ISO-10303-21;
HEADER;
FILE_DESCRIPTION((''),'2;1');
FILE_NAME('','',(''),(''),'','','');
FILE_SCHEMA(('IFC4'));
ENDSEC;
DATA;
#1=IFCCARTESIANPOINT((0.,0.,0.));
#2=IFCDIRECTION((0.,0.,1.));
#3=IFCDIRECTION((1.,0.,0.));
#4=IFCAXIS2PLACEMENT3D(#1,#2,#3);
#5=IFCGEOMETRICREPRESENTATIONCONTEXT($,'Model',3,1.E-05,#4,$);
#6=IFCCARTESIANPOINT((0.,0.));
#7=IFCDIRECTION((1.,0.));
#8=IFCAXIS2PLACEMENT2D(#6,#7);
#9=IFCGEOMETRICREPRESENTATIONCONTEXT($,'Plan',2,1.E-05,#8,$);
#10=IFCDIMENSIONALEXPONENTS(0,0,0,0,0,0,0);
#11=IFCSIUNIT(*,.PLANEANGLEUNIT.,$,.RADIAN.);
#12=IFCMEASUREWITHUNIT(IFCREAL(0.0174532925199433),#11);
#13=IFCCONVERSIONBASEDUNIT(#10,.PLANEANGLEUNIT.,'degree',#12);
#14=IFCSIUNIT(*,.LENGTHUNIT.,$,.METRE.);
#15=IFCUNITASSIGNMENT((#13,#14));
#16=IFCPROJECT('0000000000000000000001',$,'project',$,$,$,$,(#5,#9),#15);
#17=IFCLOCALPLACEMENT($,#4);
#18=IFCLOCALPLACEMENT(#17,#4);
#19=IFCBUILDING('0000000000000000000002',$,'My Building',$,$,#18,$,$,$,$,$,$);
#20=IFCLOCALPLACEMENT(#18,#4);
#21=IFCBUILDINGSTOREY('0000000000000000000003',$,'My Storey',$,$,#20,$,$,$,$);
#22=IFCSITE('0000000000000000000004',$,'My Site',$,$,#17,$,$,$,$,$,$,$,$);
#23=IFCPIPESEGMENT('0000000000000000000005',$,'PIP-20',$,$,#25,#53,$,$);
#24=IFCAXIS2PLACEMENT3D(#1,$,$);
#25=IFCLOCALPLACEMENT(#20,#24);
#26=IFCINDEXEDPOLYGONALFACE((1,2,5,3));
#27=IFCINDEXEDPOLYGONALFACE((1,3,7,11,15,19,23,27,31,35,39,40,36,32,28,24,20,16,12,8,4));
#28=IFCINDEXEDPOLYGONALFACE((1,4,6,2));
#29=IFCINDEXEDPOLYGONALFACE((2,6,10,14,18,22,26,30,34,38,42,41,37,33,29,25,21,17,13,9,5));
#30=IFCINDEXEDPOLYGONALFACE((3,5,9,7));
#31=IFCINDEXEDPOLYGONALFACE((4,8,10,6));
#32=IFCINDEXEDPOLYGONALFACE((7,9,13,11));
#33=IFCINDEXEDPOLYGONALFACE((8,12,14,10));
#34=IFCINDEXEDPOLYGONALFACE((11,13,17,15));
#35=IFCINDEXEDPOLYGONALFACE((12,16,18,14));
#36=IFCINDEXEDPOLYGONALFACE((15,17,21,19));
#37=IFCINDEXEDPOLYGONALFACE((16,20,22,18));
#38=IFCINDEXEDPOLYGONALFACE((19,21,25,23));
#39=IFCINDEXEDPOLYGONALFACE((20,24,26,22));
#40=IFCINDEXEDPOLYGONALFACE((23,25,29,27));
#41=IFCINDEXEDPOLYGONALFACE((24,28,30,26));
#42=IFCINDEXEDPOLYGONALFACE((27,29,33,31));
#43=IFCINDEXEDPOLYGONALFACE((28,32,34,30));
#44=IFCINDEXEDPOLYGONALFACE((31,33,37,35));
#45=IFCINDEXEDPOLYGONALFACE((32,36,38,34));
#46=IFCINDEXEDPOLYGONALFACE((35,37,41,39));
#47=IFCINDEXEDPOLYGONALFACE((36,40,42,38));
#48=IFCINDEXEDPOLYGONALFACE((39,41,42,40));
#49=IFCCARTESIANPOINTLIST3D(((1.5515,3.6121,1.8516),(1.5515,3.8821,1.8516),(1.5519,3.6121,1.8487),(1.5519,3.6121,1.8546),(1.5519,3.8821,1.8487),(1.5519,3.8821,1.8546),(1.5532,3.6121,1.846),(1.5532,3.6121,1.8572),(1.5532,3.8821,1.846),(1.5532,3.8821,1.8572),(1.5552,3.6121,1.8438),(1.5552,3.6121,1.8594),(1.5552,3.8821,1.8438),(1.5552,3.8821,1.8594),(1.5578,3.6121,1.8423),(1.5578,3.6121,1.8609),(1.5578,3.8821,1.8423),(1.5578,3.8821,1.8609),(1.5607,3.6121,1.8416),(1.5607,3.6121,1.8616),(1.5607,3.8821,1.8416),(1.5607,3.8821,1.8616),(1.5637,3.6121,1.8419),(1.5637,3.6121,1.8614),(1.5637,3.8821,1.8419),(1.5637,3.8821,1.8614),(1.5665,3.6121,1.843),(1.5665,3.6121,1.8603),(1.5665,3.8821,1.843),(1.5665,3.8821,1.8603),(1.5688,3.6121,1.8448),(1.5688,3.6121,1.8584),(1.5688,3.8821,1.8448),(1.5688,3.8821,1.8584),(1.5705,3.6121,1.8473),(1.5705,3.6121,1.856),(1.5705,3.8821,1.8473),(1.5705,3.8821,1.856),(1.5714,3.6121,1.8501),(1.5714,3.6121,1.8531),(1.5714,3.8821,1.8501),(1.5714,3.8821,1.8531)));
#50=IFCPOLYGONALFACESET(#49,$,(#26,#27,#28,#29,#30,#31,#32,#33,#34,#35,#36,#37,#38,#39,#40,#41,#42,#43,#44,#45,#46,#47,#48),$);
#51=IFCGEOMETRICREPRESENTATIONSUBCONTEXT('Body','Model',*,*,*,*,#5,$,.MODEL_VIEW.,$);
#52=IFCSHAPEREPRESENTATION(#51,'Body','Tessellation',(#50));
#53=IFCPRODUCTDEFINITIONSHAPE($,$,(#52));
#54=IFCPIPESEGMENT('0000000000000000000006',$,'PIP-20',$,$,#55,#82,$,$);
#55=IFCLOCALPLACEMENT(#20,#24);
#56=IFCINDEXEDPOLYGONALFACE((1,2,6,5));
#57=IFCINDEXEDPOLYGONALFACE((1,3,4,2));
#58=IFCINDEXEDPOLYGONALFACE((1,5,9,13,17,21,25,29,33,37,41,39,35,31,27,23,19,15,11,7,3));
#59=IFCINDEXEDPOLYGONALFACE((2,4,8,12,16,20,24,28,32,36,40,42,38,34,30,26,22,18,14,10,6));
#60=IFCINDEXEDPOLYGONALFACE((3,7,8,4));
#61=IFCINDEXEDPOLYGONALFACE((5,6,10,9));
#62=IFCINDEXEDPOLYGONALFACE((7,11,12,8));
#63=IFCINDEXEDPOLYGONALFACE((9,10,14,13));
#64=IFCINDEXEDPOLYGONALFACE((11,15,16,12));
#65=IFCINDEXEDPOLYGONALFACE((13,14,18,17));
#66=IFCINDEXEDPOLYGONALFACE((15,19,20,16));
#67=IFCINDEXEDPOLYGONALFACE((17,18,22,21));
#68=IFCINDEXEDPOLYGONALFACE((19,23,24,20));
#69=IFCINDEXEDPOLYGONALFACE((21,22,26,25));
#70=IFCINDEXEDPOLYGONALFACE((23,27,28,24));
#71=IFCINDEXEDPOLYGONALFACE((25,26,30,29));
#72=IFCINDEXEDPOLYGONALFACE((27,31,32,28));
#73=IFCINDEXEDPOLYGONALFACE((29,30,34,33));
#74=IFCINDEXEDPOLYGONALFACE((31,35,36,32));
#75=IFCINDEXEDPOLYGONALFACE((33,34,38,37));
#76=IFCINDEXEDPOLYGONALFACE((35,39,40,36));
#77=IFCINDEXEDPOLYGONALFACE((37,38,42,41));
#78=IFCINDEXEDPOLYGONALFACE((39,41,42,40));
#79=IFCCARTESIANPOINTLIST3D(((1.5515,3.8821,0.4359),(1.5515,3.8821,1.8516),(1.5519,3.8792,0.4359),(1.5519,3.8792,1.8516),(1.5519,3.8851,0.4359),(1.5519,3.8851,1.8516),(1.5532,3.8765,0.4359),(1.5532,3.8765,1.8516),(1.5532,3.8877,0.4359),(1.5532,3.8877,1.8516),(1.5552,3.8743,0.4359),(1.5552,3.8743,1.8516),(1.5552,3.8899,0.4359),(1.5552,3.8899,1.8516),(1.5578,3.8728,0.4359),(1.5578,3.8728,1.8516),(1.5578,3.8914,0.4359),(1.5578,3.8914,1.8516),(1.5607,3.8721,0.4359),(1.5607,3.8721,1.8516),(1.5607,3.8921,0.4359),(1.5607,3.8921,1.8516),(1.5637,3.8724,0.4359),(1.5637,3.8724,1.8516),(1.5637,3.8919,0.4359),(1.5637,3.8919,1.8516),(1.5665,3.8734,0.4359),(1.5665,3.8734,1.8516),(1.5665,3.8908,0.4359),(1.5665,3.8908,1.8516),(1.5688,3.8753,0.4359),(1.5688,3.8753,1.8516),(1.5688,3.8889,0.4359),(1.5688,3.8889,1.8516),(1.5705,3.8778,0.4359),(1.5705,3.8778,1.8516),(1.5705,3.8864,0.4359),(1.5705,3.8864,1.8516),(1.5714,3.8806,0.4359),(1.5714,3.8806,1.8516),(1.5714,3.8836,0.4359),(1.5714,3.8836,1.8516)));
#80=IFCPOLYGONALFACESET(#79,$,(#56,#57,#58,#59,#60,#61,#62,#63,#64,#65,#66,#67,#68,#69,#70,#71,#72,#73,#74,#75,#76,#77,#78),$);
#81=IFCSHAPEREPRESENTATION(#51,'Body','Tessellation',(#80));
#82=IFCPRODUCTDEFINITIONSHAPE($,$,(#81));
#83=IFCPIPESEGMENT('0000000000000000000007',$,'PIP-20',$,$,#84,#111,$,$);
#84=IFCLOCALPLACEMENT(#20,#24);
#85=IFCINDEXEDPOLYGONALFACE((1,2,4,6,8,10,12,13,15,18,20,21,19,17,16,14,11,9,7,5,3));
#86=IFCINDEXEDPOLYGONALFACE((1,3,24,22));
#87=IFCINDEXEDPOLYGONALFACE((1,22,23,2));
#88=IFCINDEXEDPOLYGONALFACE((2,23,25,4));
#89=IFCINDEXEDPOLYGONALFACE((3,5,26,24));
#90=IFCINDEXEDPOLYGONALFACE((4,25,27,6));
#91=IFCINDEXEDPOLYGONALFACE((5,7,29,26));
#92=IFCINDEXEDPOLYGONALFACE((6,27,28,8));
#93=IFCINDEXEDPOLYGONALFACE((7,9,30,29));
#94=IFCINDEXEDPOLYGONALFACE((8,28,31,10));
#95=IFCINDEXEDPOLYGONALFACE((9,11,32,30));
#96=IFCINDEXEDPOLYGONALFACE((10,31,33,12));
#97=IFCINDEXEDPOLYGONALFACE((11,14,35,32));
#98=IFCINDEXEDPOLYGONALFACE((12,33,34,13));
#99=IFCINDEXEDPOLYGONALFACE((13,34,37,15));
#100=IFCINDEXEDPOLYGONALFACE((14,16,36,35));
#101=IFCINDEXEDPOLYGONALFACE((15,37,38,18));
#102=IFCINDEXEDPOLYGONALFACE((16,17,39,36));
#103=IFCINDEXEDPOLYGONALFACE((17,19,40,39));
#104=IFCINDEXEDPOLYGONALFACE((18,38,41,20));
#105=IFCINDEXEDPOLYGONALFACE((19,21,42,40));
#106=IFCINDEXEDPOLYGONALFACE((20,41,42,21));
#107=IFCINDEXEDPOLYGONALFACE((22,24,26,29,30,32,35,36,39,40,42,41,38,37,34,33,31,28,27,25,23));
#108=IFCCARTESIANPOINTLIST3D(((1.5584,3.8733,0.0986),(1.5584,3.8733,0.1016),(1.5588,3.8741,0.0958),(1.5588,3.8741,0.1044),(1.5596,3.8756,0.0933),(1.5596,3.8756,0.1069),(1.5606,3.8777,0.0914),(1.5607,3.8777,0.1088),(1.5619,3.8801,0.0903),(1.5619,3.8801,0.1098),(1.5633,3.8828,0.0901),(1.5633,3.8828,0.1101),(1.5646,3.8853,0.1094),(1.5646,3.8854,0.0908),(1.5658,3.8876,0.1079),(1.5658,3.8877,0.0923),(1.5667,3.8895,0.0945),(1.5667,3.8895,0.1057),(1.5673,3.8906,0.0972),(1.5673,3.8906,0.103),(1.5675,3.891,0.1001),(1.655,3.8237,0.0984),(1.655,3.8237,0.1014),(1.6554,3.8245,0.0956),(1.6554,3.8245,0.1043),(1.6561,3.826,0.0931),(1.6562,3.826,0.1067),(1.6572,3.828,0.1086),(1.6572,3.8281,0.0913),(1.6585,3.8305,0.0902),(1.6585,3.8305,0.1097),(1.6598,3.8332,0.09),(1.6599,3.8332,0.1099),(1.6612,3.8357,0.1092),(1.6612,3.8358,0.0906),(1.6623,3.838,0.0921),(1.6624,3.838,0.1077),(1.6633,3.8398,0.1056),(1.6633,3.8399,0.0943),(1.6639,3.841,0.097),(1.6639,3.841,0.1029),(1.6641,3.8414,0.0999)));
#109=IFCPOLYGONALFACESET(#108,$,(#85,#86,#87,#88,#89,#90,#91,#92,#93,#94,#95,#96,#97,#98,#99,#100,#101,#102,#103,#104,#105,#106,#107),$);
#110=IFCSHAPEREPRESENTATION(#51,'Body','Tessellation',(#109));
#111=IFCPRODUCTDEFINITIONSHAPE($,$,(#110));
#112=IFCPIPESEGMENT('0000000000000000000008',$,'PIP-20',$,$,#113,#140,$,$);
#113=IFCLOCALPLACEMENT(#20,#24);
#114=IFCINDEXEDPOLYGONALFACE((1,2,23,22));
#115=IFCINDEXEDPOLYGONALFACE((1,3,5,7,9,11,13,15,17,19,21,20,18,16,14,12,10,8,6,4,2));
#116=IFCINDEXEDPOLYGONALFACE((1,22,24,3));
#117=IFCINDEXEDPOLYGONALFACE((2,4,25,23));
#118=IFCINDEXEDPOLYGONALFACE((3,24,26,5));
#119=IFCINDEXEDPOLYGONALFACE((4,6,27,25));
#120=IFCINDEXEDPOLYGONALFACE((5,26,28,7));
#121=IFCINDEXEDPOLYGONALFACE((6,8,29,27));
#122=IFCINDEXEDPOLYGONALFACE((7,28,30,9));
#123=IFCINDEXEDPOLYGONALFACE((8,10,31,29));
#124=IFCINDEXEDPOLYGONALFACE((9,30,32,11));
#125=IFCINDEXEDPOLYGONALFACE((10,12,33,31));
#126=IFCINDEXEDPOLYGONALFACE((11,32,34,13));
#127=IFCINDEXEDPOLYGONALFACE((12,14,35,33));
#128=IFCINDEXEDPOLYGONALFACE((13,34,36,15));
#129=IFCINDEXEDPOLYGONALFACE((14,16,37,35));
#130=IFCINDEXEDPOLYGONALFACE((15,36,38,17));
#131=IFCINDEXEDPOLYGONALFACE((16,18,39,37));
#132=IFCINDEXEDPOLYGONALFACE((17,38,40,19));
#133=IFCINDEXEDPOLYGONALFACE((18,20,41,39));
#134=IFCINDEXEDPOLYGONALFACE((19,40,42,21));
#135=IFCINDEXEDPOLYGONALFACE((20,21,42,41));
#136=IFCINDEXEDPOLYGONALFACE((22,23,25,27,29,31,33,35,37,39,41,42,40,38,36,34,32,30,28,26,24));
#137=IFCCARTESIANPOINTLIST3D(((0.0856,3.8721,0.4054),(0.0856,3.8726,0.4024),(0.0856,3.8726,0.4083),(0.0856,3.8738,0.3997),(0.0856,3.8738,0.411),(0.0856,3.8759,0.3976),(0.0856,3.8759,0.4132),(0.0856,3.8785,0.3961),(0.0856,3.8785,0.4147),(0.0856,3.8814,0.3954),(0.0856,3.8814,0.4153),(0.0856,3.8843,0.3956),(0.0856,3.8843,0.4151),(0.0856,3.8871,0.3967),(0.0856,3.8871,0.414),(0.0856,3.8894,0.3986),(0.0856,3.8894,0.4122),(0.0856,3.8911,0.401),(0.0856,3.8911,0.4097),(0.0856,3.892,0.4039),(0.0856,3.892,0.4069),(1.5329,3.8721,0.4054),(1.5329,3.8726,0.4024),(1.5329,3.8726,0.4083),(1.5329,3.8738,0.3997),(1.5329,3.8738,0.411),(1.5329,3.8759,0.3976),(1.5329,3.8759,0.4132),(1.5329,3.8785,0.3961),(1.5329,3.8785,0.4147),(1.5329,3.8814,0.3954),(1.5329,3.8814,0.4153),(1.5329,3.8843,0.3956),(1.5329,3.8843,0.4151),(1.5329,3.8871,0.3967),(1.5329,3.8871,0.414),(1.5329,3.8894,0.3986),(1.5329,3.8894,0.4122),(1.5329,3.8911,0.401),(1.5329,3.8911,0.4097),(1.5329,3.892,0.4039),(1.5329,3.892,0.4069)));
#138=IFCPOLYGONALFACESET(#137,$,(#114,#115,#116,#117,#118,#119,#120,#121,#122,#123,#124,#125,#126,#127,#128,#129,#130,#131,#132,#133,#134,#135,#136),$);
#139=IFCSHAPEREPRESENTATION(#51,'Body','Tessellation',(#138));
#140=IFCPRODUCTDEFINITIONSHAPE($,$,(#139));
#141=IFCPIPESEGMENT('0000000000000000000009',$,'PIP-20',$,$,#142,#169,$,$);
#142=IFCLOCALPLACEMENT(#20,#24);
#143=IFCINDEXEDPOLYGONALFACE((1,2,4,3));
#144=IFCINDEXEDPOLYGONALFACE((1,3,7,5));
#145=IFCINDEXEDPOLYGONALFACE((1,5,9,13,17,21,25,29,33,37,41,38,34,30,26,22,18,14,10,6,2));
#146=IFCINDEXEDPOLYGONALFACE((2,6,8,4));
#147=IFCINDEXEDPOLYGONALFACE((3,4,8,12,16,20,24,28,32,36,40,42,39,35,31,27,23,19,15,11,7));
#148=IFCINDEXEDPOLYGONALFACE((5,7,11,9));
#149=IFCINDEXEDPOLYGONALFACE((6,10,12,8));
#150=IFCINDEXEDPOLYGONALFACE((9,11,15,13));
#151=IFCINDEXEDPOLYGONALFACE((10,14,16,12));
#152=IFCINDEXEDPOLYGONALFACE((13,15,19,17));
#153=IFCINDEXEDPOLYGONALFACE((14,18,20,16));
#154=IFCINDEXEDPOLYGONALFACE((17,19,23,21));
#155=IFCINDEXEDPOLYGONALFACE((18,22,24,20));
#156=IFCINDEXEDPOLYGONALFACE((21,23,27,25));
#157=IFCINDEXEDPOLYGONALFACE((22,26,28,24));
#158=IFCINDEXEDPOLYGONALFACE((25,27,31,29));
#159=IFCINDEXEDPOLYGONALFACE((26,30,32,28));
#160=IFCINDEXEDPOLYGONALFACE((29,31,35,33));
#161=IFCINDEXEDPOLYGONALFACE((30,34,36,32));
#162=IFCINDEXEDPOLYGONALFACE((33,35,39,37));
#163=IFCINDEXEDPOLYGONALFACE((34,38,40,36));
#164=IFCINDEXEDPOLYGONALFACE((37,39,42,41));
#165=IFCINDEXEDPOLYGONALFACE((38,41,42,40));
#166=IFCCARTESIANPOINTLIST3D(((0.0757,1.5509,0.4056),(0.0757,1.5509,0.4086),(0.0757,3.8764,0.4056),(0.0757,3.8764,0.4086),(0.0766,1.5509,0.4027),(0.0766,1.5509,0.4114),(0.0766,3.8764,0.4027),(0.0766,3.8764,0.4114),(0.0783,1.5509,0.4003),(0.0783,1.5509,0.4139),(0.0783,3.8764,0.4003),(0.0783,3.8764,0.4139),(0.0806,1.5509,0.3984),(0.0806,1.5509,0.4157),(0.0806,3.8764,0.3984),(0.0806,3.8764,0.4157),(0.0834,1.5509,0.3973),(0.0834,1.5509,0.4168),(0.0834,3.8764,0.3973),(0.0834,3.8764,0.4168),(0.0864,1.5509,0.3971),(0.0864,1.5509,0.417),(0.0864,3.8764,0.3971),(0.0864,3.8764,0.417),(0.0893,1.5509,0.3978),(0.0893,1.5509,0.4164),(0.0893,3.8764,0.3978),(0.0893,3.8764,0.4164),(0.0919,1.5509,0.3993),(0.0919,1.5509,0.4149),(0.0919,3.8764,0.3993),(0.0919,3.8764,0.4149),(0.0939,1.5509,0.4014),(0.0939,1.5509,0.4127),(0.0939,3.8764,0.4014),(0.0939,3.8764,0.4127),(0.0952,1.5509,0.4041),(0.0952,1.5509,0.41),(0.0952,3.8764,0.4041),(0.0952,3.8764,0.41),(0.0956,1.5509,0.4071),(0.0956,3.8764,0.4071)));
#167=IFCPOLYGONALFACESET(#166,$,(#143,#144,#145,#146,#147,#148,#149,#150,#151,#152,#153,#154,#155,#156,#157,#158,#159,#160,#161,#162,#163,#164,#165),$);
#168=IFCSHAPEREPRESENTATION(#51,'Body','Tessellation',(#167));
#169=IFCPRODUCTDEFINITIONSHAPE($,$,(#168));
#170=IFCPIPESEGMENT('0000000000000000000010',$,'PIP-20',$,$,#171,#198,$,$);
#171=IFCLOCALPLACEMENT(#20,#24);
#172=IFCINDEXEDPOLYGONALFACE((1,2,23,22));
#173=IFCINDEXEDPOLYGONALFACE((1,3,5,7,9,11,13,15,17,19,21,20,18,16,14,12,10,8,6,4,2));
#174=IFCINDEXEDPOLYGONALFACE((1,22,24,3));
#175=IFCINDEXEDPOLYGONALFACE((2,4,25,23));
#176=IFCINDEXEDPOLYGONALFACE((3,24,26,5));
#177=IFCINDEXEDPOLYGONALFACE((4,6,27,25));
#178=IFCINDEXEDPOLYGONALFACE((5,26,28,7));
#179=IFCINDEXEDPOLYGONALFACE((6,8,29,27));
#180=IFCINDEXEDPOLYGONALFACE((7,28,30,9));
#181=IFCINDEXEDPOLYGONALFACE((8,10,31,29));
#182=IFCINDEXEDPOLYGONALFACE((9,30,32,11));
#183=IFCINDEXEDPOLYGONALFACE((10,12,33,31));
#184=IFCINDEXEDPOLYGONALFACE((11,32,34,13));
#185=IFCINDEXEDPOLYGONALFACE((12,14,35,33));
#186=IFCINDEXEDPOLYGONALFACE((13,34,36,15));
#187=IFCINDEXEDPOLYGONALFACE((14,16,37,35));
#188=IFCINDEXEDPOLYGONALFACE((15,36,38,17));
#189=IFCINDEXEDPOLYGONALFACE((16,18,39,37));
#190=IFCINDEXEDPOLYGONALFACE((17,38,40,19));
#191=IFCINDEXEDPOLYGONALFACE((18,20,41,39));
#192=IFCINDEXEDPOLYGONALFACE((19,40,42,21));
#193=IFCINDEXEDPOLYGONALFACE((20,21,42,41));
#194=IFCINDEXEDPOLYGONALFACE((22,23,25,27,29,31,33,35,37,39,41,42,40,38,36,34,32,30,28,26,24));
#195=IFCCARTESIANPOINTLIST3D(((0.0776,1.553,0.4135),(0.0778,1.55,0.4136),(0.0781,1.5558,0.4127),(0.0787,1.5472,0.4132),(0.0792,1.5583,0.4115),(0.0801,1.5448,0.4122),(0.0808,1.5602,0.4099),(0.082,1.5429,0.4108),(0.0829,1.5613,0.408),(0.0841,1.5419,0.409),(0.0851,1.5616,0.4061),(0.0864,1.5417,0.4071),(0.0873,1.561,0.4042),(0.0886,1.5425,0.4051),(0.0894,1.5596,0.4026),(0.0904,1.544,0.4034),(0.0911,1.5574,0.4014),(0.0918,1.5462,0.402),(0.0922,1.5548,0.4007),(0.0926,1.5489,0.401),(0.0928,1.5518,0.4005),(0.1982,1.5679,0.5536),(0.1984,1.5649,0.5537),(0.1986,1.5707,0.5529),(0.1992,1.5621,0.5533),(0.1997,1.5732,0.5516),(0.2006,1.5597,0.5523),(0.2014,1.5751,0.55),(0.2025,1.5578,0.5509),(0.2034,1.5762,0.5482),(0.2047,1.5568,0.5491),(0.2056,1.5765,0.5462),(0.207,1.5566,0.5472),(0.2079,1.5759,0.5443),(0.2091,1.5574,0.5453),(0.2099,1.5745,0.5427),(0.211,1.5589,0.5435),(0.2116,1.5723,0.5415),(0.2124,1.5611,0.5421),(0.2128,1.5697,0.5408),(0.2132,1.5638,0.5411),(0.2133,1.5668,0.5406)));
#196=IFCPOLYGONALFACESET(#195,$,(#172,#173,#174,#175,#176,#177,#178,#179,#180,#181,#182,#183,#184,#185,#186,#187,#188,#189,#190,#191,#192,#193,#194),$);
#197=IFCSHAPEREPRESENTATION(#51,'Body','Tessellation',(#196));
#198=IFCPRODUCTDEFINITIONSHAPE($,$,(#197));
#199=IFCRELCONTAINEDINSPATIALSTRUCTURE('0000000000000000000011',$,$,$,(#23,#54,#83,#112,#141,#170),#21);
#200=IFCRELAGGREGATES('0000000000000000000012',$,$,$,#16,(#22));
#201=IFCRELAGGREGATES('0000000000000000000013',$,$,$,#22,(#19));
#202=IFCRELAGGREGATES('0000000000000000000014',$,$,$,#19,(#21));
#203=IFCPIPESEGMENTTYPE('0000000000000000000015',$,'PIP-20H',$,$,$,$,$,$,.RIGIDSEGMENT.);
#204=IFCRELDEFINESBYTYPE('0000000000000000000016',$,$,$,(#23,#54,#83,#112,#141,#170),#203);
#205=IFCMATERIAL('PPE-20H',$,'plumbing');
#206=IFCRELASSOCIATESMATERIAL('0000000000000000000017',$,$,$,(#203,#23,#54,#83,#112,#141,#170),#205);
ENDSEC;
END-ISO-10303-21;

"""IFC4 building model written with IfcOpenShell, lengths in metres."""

from ifc_helpers import new_model, entity, si_unit, converted_unit, frame, origin_with_axes, origin_2d_with_axis, place, context, subcontext, project, spatial, circle, extrude, material, material_profile, profile_set, profile_usage, type_object, element, save


model = new_model("IFC4")

# Units and contexts
model_context = context("Model", 3, precision=1e-05, world=origin_with_axes())
plan_context = context("Plan", 2, precision=1e-05, world=origin_2d_with_axis())
body_context = subcontext(model_context, "Body", "Model", "MODEL_VIEW")
ifc_project = project(units=[converted_unit("PLANEANGLEUNIT", "degree", entity("IfcReal", 0.0174532925199433), si_unit("PLANEANGLEUNIT", "RADIAN"), dimensions=[0, 0, 0, 0, 0, 0, 0]), si_unit("LENGTHUNIT", "METRE")], contexts=[model_context, plan_context])

# Site, building, storey
site_placement = place(None, origin_with_axes())
site = spatial("IfcSite", under=ifc_project, at=site_placement, Name="My Site")
building_placement = place(site_placement, origin_with_axes())
building = spatial("IfcBuilding", under=site, at=building_placement, Name="My Building")
storey_placement = place(building_placement, origin_with_axes())
storey = spatial("IfcBuildingStorey", under=building, at=storey_placement, Name="My Storey")

# Pipe segments
ifc_material_1 = material(Name="PPE-20H", Category="plumbing")
ifc_material_profile_1 = material_profile(ifc_material_1, circle(Radius=0.01, kind="CURVE"))
ifc_profile_set_1 = profile_set([ifc_material_profile_1])
pipe_segment_type_1 = type_object("IfcPipeSegmentType", Name="PIP-20H", PredefinedType="RIGIDSEGMENT", material=ifc_profile_set_1)
ifc_profile_usage_1 = profile_usage(ifc_profile_set_1, cardinal=5)
pipe_segment_1_placement = place(storey_placement, frame((1.5615, 3.6121, 1.8516), z_axis=(0.0, 1.0, 0.0), x_axis=(-1.0, 0.0, 0.0)))
element("IfcPipeSegment", 1, at=pipe_segment_1_placement, inside=storey, type_object=pipe_segment_type_1, material=ifc_profile_usage_1, Name="PIP-20", context=body_context, shape_type="SweptSolid", body=[
    extrude(circle(Radius=0.01, kind="CURVE"), origin_with_axes(), (0.0, 0.0, 1.0), 0.27),
])
ifc_profile_usage_2 = profile_usage(ifc_profile_set_1, cardinal=5)
pipe_segment_2_placement = place(storey_placement, frame((1.5615, 3.8821, 1.8516), z_axis=(0.0, 0.0, -1.0), x_axis=(-1.0, 0.0, 0.0)))
element("IfcPipeSegment", 2, at=pipe_segment_2_placement, inside=storey, type_object=pipe_segment_type_1, material=ifc_profile_usage_2, Name="PIP-20", context=body_context, shape_type="SweptSolid", body=[
    extrude(circle(Radius=0.01, kind="CURVE"), origin_with_axes(), (0.0, 0.0, 1.0), 1.4157),
])
ifc_profile_usage_3 = profile_usage(ifc_profile_set_1, cardinal=5)
pipe_segment_3_placement = place(storey_placement, frame((1.5629, 3.8821, 0.1001), z_axis=(0.889495, -0.456942, -0.0016), x_axis=(0.456942, 0.889496, 0.0)))
element("IfcPipeSegment", 3, at=pipe_segment_3_placement, inside=storey, type_object=pipe_segment_type_1, material=ifc_profile_usage_3, Name="PIP-20", context=body_context, shape_type="SweptSolid", body=[
    extrude(circle(Radius=0.01, kind="CURVE"), origin_with_axes(), (0.0, 0.0, 1.0), 0.1086),
])
ifc_profile_usage_4 = profile_usage(ifc_profile_set_1, cardinal=5)
pipe_segment_4_placement = place(storey_placement, frame((1.5329, 3.8821, 0.4054), z_axis=(-1.0, 0.0, 0.0), x_axis=(0.0, -1.0, 0.0)))
element("IfcPipeSegment", 4, at=pipe_segment_4_placement, inside=storey, type_object=pipe_segment_type_1, material=ifc_profile_usage_4, Name="PIP-20", context=body_context, shape_type="SweptSolid", body=[
    extrude(circle(Radius=0.01, kind="CURVE"), origin_with_axes(), (0.0, 0.0, 1.0), 1.4473),
])
ifc_profile_usage_5 = profile_usage(ifc_profile_set_1, cardinal=5)
pipe_segment_5_placement = place(storey_placement, frame((0.0856, 3.8764, 0.4071), z_axis=(0.0, -1.0, 0.0), x_axis=(1.0, 0.0, 0.0)))
element("IfcPipeSegment", 5, at=pipe_segment_5_placement, inside=storey, type_object=pipe_segment_type_1, material=ifc_profile_usage_5, Name="PIP-20", context=body_context, shape_type="SweptSolid", body=[
    extrude(circle(Radius=0.01, kind="CURVE"), origin_with_axes(), (0.0, 0.0, 1.0), 2.3255),
])
ifc_profile_usage_6 = profile_usage(ifc_profile_set_1, cardinal=5)
pipe_segment_6_placement = place(storey_placement, frame((0.2057, 1.5666, 0.5472), z_axis=(-0.650124, -0.080393, -0.755563), x_axis=(0.122724, -0.992441, 0.0)))
element("IfcPipeSegment", 6, at=pipe_segment_6_placement, inside=storey, type_object=pipe_segment_type_1, material=ifc_profile_usage_6, Name="PIP-20", context=body_context, shape_type="SweptSolid", body=[
    extrude(circle(Radius=0.01, kind="CURVE"), origin_with_axes(), (0.0, 0.0, 1.0), 0.1854),
])

save(model, "model.ifc")
